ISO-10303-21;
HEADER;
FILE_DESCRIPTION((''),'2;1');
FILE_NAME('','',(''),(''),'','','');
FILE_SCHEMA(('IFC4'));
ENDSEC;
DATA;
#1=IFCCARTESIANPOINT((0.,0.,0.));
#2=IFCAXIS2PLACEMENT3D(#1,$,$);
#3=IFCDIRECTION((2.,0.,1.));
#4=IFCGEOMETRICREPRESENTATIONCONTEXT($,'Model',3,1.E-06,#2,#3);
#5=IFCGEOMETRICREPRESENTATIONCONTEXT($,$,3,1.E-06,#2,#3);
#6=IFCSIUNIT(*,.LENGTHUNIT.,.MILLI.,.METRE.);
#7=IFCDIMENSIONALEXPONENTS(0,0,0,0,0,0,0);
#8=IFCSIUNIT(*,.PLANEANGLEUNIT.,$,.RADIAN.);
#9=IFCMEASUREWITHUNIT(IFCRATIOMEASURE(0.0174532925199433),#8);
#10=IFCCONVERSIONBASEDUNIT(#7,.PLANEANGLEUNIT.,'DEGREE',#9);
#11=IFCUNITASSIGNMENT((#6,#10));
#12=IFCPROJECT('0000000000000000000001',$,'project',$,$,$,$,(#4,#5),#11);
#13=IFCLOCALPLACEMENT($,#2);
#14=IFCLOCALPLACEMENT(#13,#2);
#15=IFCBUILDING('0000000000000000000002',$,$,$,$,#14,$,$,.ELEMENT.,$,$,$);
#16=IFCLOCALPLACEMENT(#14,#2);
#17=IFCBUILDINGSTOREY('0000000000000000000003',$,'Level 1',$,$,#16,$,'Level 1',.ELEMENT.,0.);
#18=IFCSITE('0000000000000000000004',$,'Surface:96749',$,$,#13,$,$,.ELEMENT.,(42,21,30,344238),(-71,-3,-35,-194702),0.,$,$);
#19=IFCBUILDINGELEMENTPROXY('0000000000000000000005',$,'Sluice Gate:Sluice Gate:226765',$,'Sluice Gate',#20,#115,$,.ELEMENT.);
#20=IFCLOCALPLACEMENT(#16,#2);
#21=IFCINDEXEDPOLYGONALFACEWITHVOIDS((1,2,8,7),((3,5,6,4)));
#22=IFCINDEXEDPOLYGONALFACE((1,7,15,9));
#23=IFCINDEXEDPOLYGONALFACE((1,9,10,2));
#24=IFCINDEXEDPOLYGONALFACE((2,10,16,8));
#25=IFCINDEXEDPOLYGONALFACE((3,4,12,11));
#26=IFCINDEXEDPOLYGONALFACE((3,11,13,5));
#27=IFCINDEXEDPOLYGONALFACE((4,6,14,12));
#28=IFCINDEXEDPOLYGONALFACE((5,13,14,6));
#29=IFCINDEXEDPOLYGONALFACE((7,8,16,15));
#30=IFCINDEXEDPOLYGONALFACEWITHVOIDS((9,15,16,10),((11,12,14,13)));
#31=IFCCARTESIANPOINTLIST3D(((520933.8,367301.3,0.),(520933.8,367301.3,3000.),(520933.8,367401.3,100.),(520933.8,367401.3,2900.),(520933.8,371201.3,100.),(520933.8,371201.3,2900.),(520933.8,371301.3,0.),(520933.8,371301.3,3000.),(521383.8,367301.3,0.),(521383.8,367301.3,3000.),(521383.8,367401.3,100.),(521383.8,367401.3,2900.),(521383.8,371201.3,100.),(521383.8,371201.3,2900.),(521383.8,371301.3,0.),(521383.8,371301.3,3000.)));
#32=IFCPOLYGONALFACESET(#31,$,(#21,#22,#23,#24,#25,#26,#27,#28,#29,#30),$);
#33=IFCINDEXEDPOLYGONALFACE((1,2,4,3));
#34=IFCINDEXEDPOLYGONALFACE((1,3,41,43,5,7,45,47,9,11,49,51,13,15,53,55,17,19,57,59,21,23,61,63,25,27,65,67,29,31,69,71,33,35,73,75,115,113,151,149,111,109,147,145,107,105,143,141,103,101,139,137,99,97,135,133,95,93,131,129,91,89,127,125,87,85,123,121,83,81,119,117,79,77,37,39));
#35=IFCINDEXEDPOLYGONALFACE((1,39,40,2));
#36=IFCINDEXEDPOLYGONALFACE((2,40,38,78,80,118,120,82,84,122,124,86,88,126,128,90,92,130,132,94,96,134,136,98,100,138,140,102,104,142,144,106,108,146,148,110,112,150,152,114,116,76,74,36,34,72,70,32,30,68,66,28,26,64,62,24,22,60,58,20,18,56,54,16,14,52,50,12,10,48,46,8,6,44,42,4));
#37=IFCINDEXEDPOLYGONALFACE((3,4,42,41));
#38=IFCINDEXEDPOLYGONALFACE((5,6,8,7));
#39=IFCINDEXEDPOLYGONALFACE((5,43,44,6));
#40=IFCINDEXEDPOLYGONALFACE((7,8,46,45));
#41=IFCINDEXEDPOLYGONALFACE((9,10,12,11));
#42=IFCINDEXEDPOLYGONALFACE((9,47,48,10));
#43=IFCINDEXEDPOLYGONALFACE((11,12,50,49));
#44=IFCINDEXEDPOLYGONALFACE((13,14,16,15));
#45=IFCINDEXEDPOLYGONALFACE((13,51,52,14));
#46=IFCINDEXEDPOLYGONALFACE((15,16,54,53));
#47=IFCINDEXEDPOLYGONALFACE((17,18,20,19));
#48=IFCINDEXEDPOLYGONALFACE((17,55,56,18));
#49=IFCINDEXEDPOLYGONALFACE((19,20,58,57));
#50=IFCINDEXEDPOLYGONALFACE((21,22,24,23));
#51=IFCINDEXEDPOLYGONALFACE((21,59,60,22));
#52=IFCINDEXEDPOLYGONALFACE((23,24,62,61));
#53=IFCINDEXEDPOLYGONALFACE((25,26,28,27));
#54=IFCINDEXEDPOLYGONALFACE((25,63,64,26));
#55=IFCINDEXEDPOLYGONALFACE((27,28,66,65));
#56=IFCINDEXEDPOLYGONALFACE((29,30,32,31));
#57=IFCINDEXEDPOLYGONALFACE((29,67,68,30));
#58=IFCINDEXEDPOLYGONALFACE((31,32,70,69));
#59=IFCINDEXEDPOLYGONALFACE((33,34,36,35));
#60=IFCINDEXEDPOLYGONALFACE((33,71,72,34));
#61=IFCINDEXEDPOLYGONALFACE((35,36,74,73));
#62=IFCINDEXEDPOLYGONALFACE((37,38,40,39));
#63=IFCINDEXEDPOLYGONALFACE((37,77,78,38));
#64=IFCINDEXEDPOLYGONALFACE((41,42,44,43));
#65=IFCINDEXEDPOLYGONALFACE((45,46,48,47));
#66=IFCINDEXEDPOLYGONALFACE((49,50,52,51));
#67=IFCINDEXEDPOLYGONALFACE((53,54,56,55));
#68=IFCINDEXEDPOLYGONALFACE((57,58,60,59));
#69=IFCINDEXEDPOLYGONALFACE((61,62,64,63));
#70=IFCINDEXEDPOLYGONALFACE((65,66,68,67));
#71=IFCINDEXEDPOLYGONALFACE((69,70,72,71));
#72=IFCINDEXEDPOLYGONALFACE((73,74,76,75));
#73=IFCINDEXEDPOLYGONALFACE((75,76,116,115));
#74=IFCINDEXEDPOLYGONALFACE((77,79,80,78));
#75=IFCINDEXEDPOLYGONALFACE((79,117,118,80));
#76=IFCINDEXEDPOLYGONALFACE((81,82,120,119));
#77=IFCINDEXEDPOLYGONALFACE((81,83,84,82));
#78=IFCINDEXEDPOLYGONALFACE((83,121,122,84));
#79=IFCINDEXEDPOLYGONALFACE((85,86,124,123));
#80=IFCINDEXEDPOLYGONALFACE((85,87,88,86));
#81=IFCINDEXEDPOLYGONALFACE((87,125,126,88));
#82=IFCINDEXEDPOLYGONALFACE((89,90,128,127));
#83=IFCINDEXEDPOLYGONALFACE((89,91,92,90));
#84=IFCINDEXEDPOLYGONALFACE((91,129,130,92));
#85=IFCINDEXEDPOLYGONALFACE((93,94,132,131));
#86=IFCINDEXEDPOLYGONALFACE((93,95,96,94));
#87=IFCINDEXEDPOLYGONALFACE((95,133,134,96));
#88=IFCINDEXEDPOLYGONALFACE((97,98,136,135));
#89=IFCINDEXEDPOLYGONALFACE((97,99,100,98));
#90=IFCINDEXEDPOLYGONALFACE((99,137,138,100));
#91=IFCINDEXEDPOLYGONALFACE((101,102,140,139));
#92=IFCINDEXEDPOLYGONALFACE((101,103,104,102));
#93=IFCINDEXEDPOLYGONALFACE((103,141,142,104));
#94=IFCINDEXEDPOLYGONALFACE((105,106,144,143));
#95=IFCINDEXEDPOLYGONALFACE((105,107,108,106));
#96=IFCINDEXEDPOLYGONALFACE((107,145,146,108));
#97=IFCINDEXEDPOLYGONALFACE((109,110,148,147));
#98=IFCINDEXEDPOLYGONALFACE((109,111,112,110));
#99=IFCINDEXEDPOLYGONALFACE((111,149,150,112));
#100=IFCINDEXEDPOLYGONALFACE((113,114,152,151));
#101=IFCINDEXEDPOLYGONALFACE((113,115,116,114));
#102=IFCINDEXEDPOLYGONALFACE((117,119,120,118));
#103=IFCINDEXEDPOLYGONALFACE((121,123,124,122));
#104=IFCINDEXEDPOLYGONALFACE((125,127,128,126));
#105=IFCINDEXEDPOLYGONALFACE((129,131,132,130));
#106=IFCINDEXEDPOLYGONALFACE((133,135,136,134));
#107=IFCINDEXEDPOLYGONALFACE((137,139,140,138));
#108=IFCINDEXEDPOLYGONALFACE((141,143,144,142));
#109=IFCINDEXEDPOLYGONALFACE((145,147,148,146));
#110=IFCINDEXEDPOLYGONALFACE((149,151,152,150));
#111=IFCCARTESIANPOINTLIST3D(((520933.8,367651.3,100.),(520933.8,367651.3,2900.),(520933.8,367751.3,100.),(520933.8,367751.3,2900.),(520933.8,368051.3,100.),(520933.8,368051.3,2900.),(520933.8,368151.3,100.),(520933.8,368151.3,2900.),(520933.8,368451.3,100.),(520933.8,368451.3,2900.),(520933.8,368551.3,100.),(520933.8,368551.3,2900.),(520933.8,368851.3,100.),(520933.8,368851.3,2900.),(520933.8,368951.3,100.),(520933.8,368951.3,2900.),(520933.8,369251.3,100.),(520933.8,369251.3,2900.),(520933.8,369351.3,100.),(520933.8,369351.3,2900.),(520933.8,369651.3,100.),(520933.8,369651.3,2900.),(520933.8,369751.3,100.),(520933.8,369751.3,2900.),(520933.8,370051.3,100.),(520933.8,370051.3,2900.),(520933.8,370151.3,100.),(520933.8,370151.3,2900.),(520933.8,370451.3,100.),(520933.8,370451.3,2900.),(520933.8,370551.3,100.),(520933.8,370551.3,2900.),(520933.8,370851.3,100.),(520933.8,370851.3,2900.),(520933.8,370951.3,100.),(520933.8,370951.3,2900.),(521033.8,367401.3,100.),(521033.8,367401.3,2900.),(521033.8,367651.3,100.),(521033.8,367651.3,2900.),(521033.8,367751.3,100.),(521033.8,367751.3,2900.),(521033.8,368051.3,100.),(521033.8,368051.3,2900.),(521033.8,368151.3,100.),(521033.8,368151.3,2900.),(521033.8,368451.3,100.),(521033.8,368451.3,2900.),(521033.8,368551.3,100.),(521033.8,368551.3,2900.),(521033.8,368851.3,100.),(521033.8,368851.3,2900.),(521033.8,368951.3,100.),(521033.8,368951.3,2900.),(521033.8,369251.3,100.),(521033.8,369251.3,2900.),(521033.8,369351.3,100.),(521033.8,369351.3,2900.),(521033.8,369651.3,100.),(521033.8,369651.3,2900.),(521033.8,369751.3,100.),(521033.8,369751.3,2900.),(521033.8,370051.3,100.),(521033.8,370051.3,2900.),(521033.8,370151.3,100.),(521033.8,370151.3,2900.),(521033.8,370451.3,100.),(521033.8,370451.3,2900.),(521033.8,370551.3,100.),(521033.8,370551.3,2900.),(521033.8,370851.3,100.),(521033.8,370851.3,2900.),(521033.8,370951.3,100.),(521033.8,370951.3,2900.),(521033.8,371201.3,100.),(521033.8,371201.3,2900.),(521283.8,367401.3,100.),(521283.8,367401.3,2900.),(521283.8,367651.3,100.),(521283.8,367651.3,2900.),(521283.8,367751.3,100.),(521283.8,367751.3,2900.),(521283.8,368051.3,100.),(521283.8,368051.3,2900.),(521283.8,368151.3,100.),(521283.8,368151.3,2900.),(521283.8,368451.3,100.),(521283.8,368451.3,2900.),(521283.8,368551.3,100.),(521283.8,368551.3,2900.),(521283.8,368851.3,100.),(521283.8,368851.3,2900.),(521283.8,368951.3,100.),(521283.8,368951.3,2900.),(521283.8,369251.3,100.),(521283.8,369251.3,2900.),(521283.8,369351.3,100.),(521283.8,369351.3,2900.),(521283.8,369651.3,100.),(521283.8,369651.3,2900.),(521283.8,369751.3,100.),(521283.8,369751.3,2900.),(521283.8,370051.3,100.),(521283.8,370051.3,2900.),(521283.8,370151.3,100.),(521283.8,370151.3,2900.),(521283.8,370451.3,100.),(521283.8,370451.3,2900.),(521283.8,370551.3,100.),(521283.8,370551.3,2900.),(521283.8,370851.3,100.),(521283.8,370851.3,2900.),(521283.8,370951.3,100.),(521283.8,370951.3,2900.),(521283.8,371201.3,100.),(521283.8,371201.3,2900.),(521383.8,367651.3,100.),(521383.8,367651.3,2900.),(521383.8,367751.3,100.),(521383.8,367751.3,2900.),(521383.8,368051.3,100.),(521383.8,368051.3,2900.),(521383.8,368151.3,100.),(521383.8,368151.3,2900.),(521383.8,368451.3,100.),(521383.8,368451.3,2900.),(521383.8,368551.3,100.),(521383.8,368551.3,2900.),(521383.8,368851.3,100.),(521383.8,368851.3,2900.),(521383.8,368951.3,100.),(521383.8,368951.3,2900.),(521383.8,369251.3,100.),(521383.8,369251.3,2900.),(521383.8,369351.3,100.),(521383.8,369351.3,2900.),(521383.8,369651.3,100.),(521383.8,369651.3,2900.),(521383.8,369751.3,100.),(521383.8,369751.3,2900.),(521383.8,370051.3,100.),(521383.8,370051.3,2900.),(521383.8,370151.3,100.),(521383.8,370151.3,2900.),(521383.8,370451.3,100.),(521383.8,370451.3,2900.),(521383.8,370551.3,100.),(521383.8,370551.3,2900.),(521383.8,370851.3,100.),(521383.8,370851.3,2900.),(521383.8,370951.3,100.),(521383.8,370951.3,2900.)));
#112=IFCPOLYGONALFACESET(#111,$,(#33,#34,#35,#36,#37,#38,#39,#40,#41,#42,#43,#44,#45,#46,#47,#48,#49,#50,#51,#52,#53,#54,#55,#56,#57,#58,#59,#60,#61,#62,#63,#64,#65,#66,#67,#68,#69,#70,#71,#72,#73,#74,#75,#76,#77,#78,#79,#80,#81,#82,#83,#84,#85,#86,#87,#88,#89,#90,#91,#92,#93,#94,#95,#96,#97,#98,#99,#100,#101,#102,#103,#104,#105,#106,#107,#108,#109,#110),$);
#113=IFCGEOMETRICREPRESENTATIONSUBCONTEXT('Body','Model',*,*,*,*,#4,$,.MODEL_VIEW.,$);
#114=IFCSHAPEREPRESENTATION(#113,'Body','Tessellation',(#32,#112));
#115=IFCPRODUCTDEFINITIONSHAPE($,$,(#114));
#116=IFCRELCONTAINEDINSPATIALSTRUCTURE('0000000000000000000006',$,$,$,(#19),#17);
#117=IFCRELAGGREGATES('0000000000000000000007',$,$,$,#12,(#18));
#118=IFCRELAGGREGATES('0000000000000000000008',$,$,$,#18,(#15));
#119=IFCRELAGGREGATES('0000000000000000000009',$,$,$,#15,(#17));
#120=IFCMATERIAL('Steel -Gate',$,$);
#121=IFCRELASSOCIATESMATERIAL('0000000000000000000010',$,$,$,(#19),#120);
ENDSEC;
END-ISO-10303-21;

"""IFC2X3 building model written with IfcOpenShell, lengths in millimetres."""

from ifc_helpers import new_model, entity, si_unit, converted_unit, direction, frame, origin, place, context, subcontext, project, spatial, polyline, outline, extrude, source, transform, mapped, material, element, save


model = new_model("IFC2X3")

# Units and contexts
model_context = context("Model", 3, precision=1e-06, world=origin(), true_north=direction((2.0, 0.0, 1.0)))
context_of_model = context(None, 3, precision=1e-06, world=origin(), true_north=direction((2.0, 0.0, 1.0)))
body_context = subcontext(model_context, "Body", "Model", "MODEL_VIEW")
ifc_project = project(units=[si_unit("LENGTHUNIT", "METRE", prefix="MILLI"), converted_unit("PLANEANGLEUNIT", "DEGREE", entity("IfcRatioMeasure", 0.0174532925199433), si_unit("PLANEANGLEUNIT", "RADIAN"), dimensions=[0, 0, 0, 0, 0, 0, 0])], contexts=[model_context, context_of_model])

# Site, building, storey
site_placement = place(None, origin())
site = spatial("IfcSite", under=ifc_project, at=site_placement, Name="Surface:96749", CompositionType="ELEMENT", RefLatitude=(42, 21, 30, 344238), RefLongitude=(-71, -3, -35, -194702), RefElevation=0.0)
building_placement = place(site_placement, origin())
building = spatial("IfcBuilding", under=site, at=building_placement, CompositionType="ELEMENT")
storey_placement = place(building_placement, origin())
storey = spatial("IfcBuildingStorey", under=building, at=storey_placement, Name="Level 1", LongName="Level 1", CompositionType="ELEMENT", Elevation=0.0)

# Building element proxy
ifc_material = material(Name="Steel -Gate")
shared_shape_1 = source(origin(), body_context, "Body", "SweptSolid", [
    extrude(outline(polyline([(-1500.0, -2000.0), (1500.0, -2000.0), (1500.0, 2000.0), (-1500.0, 2000.0), (-1500.0, -2000.0)]), holes=[polyline([(1400.0, -1900.0), (-1400.0, -1900.0), (-1400.0, 1900.0), (1400.0, 1900.0), (1400.0, -1900.0)])]), frame((0.0, -225.0, 1500.0), z_axis=(0.0, 1.0, 0.0), x_axis=(0.0, 0.0, -1.0)), (0.0, 0.0, 1.0), 450.0),
    extrude(outline(polyline([(1650.0, -125.0), (1900.0, -125.0), (1900.0, 125.0), (1650.0, 125.0), (1650.0, 225.0), (1550.0, 225.0), (1550.0, 125.0), (1250.0, 125.0), (1250.0, 225.0), (1150.0, 225.0), (1150.0, 125.0), (850.0, 125.0), (850.0, 225.0), (750.0, 225.0), (750.0, 125.0), (450.0, 125.0), (450.0, 225.0), (350.0, 225.0), (350.0, 125.0), (50.0, 125.0), (50.0, 225.0), (-50.0, 225.0), (-50.0, 125.0), (-350.0, 125.0), (-350.0, 225.0), (-450.0, 225.0), (-450.0, 125.0), (-750.0, 125.0), (-750.0, 225.0), (-850.0, 225.0), (-850.0, 125.0), (-1150.0, 125.0), (-1150.0, 225.0), (-1250.0, 225.0), (-1250.0, 125.0), (-1550.0, 125.0), (-1550.0, 225.0), (-1650.0, 225.0), (-1650.0, 125.0), (-1900.0, 125.0), (-1900.0, -125.0), (-1650.0, -125.0), (-1650.0, -225.0), (-1550.0, -225.0), (-1550.0, -125.0), (-1250.0, -125.0), (-1250.0, -225.0), (-1150.0, -225.0), (-1150.0, -125.0), (-850.0, -125.0), (-850.0, -225.0), (-750.0, -225.0), (-750.0, -125.0), (-450.0, -125.0), (-450.0, -225.0), (-350.0, -225.0), (-350.0, -125.0), (-50.0, -125.0), (-50.0, -225.0), (50.0, -225.0), (50.0, -125.0), (350.0, -125.0), (350.0, -225.0), (450.0, -225.0), (450.0, -125.0), (750.0, -125.0), (750.0, -225.0), (850.0, -225.0), (850.0, -125.0), (1150.0, -125.0), (1150.0, -225.0), (1250.0, -225.0), (1250.0, -125.0), (1550.0, -125.0), (1550.0, -225.0), (1650.0, -225.0), (1650.0, -125.0)])), frame((0.0, 0.0, 100.0), z_axis=(0.0, 0.0, 1.0), x_axis=(-1.0, 0.0, 0.0)), (0.0, 0.0, 1.0), 2800.0),
])
for number, where, z_axis, x_axis, name in (
    (1, (521158.8, 369301.3, 0.0), (0.0, 0.0, 1.0), (0.0, 1.0, 0.0), "Sluice Gate:Sluice Gate:226765"),
):
    element("IfcBuildingElementProxy", number, at=place(storey_placement, frame(where, z_axis=z_axis, x_axis=x_axis)), inside=storey, material=ifc_material, Name=name, ObjectType="Sluice Gate", CompositionType="ELEMENT", context=body_context, shape_type="MappedRepresentation", body=[
        mapped(shared_shape_1, transform((0.0, 0.0, 0.0), scale=1.0)),
    ])

save(model, "model.ifc")
